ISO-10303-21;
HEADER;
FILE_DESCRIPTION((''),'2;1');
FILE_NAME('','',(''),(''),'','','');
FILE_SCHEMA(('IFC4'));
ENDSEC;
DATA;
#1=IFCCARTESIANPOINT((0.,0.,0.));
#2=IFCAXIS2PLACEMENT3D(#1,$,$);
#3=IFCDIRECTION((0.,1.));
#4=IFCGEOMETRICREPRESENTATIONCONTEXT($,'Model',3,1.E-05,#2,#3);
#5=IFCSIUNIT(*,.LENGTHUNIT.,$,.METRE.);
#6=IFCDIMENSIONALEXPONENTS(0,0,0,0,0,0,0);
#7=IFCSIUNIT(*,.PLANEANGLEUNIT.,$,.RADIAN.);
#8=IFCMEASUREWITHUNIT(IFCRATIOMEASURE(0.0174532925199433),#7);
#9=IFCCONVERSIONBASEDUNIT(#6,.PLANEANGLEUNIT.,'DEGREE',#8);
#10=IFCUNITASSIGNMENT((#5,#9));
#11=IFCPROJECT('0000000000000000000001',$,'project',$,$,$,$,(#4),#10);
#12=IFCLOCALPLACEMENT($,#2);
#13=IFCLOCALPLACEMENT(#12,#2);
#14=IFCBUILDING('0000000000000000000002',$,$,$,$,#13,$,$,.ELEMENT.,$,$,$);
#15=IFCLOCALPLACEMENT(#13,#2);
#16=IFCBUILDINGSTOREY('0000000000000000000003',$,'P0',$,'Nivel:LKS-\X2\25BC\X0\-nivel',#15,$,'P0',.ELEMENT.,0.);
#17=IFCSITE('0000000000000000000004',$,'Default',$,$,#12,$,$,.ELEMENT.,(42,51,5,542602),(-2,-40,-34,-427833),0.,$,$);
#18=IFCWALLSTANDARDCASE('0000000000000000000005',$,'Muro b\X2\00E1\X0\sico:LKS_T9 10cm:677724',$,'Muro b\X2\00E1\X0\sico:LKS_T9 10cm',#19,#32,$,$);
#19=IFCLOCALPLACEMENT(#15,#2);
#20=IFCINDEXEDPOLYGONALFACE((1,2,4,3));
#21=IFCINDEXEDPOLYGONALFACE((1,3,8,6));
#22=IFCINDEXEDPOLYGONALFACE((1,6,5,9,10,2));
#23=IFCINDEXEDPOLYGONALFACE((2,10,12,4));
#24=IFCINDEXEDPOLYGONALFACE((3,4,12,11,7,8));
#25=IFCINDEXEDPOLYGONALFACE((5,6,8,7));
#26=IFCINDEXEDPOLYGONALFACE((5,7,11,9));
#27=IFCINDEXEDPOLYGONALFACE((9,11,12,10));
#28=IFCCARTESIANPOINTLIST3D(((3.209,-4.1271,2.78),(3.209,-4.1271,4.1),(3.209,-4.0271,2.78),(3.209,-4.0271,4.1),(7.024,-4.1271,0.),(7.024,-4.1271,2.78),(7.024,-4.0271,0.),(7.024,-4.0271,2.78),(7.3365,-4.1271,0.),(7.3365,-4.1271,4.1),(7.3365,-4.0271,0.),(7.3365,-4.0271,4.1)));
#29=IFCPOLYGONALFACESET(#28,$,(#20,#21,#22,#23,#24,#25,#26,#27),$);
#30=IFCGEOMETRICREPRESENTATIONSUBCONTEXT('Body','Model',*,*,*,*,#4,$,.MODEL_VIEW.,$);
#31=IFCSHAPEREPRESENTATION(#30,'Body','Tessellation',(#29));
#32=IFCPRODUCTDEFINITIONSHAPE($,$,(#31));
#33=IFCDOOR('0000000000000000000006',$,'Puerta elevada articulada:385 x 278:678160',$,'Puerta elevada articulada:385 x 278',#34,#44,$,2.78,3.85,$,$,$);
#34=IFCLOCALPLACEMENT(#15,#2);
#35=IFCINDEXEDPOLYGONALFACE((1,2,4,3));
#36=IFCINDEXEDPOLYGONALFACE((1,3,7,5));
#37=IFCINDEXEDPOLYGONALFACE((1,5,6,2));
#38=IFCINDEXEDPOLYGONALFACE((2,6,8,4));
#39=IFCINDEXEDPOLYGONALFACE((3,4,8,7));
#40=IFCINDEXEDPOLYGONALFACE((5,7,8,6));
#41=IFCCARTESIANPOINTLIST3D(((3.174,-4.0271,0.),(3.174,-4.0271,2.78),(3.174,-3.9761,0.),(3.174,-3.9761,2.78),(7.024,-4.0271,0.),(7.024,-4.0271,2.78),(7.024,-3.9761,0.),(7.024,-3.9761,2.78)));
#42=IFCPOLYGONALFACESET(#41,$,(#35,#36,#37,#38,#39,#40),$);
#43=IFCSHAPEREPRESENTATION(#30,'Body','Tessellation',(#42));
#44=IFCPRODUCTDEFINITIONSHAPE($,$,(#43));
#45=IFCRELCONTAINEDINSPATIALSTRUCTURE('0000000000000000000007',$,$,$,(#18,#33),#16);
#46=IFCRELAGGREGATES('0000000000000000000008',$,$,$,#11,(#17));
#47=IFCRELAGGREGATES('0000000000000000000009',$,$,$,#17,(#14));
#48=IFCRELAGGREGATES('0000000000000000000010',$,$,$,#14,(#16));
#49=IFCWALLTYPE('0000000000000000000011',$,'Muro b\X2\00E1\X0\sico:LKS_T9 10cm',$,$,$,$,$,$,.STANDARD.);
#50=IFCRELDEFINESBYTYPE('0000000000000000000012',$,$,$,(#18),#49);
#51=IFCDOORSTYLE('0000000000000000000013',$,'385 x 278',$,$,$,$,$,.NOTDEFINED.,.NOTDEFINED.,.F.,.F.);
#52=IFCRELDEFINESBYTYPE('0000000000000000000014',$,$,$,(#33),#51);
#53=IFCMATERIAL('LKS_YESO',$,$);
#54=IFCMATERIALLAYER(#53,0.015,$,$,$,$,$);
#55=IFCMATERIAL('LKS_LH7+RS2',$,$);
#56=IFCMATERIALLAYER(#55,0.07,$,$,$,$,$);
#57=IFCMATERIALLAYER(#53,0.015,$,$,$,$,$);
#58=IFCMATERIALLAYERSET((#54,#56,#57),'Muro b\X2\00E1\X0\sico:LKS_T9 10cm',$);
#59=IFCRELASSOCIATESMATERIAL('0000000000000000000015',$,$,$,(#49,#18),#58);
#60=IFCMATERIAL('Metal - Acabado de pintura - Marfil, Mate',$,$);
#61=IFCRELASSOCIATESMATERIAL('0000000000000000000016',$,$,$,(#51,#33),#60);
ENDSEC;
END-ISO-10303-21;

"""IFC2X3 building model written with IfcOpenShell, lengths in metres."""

from ifc_helpers import new_model, entity, si_unit, converted_unit, direction, frame, frame_2d, origin, place, context, subcontext, project, spatial, rectangle, extrude, source, transform, mapped, material, layer, layer_set, layer_usage, type_object, type_shapes, element, fill, save


model = new_model("IFC2X3")

# Units and contexts
model_context = context("Model", 3, precision=1e-05, world=origin(), true_north=direction((0.0, 1.0)))
body_context = subcontext(model_context, "Body", "Model", "MODEL_VIEW")
ifc_project = project(units=[si_unit("LENGTHUNIT", "METRE"), converted_unit("PLANEANGLEUNIT", "DEGREE", entity("IfcRatioMeasure", 0.0174532925199433), si_unit("PLANEANGLEUNIT", "RADIAN"), dimensions=[0, 0, 0, 0, 0, 0, 0])], contexts=[model_context])

# Site, building, storey
site_placement = place(None, origin())
site = spatial("IfcSite", under=ifc_project, at=site_placement, Name="Default", CompositionType="ELEMENT", RefLatitude=(42, 51, 5, 542602), RefLongitude=(-2, -40, -34, -427833), RefElevation=0.0)
building_placement = place(site_placement, origin())
building = spatial("IfcBuilding", under=site, at=building_placement, CompositionType="ELEMENT")
storey_placement = place(building_placement, origin())
storey = spatial("IfcBuildingStorey", under=building, at=storey_placement, Name="P0", ObjectType="Nivel:LKS-▼-nivel", LongName="P0", CompositionType="ELEMENT", Elevation=0.0)

# Shared definitions
ifc_material_1 = material(Name="LKS_YESO")

# Shared definitions
ifc_layer_1 = layer(ifc_material_1, 0.015)
ifc_material_2 = material(Name="LKS_LH7+RS2")
ifc_layer_2 = layer(ifc_material_2, 0.07)
ifc_layer_3 = layer(ifc_material_1, 0.015)
ifc_layer_set_1 = layer_set([ifc_layer_1, ifc_layer_2, ifc_layer_3], Name="Muro básico:LKS_T9 10cm")
wall_type_1 = type_object("IfcWallType", Name="Muro básico:LKS_T9 10cm", PredefinedType="STANDARD", material=ifc_layer_set_1)

# Wall, opening, door
ifc_layer_usage_1 = layer_usage(ifc_layer_set_1, "AXIS2", "NEGATIVE", 0.05)
wall_1_placement = place(storey_placement, frame((3.209, -4.0771, 0.0)))
wall_1 = element("IfcWallStandardCase", 1, at=wall_1_placement, inside=storey, type_object=wall_type_1, material=ifc_layer_usage_1, Name="Muro básico:LKS_T9 10cm:677724", ObjectType="Muro básico:LKS_T9 10cm", context=body_context, shape_type="SweptSolid", body=[
    extrude(rectangle(XDim=4.1276, YDim=0.1, at=frame_2d((2.0638, 0.0), x_axis=(-1.0, 0.0))), origin(), (0.0, 0.0, 1.0), 4.1),
])
opening_1_placement = place(wall_1_placement, frame((-0.035, -0.05, 0.0)))
opening_1 = element("IfcOpeningElement", 2, at=opening_1_placement, cuts=wall_1, ObjectType="Opening", context=body_context, shape_type="SweptSolid", body=[
    extrude(rectangle(XDim=2.78, YDim=3.85, at=frame_2d((1.39, 1.925), x_axis=(1.0, 0.0))), frame((0.0, 0.0, 0.0), z_axis=(0.0, 1.0, 0.0), x_axis=(0.0, 0.0, 1.0)), (0.0, 0.0, 1.0), 0.1),
])
ifc_material_3 = material(Name="Metal - Acabado de pintura - Marfil, Mate")
door_style = type_object("IfcDoorStyle", Name="385 x 278", ConstructionType="NOTDEFINED", OperationType="NOTDEFINED", ParameterTakesPrecedence=False, Sizeable=False, material=ifc_material_3)
shared_shape_1 = source(origin(), body_context, "Body", "SweptSolid", [
    extrude(rectangle(XDim=3.85, YDim=0.051, at=frame_2d((0.0, 0.0), x_axis=(1.0, 0.0))), frame((1.925, -0.0255, 0.0), z_axis=(0.0, 0.0, 1.0), x_axis=(-1.0, 0.0, 0.0)), (0.0, 0.0, 1.0), 2.78),
])
type_shapes(door_style, [shared_shape_1])
door_placement = place(opening_1_placement, frame((3.85, 0.1, 0.0), z_axis=(0.0, 0.0, 1.0), x_axis=(-1.0, 0.0, 0.0)))
door = element("IfcDoor", 3, at=door_placement, inside=storey, type_object=door_style, material=ifc_material_3, Name="Puerta elevada articulada:385 x 278:678160", ObjectType="Puerta elevada articulada:385 x 278", OverallHeight=2.78, OverallWidth=3.85, context=body_context, shape_type="MappedRepresentation", body=[
    mapped(shared_shape_1, transform((0.0, 0.0, 0.0), scale=1.0)),
])
fill(opening_1, door)

save(model, "model.ifc")
